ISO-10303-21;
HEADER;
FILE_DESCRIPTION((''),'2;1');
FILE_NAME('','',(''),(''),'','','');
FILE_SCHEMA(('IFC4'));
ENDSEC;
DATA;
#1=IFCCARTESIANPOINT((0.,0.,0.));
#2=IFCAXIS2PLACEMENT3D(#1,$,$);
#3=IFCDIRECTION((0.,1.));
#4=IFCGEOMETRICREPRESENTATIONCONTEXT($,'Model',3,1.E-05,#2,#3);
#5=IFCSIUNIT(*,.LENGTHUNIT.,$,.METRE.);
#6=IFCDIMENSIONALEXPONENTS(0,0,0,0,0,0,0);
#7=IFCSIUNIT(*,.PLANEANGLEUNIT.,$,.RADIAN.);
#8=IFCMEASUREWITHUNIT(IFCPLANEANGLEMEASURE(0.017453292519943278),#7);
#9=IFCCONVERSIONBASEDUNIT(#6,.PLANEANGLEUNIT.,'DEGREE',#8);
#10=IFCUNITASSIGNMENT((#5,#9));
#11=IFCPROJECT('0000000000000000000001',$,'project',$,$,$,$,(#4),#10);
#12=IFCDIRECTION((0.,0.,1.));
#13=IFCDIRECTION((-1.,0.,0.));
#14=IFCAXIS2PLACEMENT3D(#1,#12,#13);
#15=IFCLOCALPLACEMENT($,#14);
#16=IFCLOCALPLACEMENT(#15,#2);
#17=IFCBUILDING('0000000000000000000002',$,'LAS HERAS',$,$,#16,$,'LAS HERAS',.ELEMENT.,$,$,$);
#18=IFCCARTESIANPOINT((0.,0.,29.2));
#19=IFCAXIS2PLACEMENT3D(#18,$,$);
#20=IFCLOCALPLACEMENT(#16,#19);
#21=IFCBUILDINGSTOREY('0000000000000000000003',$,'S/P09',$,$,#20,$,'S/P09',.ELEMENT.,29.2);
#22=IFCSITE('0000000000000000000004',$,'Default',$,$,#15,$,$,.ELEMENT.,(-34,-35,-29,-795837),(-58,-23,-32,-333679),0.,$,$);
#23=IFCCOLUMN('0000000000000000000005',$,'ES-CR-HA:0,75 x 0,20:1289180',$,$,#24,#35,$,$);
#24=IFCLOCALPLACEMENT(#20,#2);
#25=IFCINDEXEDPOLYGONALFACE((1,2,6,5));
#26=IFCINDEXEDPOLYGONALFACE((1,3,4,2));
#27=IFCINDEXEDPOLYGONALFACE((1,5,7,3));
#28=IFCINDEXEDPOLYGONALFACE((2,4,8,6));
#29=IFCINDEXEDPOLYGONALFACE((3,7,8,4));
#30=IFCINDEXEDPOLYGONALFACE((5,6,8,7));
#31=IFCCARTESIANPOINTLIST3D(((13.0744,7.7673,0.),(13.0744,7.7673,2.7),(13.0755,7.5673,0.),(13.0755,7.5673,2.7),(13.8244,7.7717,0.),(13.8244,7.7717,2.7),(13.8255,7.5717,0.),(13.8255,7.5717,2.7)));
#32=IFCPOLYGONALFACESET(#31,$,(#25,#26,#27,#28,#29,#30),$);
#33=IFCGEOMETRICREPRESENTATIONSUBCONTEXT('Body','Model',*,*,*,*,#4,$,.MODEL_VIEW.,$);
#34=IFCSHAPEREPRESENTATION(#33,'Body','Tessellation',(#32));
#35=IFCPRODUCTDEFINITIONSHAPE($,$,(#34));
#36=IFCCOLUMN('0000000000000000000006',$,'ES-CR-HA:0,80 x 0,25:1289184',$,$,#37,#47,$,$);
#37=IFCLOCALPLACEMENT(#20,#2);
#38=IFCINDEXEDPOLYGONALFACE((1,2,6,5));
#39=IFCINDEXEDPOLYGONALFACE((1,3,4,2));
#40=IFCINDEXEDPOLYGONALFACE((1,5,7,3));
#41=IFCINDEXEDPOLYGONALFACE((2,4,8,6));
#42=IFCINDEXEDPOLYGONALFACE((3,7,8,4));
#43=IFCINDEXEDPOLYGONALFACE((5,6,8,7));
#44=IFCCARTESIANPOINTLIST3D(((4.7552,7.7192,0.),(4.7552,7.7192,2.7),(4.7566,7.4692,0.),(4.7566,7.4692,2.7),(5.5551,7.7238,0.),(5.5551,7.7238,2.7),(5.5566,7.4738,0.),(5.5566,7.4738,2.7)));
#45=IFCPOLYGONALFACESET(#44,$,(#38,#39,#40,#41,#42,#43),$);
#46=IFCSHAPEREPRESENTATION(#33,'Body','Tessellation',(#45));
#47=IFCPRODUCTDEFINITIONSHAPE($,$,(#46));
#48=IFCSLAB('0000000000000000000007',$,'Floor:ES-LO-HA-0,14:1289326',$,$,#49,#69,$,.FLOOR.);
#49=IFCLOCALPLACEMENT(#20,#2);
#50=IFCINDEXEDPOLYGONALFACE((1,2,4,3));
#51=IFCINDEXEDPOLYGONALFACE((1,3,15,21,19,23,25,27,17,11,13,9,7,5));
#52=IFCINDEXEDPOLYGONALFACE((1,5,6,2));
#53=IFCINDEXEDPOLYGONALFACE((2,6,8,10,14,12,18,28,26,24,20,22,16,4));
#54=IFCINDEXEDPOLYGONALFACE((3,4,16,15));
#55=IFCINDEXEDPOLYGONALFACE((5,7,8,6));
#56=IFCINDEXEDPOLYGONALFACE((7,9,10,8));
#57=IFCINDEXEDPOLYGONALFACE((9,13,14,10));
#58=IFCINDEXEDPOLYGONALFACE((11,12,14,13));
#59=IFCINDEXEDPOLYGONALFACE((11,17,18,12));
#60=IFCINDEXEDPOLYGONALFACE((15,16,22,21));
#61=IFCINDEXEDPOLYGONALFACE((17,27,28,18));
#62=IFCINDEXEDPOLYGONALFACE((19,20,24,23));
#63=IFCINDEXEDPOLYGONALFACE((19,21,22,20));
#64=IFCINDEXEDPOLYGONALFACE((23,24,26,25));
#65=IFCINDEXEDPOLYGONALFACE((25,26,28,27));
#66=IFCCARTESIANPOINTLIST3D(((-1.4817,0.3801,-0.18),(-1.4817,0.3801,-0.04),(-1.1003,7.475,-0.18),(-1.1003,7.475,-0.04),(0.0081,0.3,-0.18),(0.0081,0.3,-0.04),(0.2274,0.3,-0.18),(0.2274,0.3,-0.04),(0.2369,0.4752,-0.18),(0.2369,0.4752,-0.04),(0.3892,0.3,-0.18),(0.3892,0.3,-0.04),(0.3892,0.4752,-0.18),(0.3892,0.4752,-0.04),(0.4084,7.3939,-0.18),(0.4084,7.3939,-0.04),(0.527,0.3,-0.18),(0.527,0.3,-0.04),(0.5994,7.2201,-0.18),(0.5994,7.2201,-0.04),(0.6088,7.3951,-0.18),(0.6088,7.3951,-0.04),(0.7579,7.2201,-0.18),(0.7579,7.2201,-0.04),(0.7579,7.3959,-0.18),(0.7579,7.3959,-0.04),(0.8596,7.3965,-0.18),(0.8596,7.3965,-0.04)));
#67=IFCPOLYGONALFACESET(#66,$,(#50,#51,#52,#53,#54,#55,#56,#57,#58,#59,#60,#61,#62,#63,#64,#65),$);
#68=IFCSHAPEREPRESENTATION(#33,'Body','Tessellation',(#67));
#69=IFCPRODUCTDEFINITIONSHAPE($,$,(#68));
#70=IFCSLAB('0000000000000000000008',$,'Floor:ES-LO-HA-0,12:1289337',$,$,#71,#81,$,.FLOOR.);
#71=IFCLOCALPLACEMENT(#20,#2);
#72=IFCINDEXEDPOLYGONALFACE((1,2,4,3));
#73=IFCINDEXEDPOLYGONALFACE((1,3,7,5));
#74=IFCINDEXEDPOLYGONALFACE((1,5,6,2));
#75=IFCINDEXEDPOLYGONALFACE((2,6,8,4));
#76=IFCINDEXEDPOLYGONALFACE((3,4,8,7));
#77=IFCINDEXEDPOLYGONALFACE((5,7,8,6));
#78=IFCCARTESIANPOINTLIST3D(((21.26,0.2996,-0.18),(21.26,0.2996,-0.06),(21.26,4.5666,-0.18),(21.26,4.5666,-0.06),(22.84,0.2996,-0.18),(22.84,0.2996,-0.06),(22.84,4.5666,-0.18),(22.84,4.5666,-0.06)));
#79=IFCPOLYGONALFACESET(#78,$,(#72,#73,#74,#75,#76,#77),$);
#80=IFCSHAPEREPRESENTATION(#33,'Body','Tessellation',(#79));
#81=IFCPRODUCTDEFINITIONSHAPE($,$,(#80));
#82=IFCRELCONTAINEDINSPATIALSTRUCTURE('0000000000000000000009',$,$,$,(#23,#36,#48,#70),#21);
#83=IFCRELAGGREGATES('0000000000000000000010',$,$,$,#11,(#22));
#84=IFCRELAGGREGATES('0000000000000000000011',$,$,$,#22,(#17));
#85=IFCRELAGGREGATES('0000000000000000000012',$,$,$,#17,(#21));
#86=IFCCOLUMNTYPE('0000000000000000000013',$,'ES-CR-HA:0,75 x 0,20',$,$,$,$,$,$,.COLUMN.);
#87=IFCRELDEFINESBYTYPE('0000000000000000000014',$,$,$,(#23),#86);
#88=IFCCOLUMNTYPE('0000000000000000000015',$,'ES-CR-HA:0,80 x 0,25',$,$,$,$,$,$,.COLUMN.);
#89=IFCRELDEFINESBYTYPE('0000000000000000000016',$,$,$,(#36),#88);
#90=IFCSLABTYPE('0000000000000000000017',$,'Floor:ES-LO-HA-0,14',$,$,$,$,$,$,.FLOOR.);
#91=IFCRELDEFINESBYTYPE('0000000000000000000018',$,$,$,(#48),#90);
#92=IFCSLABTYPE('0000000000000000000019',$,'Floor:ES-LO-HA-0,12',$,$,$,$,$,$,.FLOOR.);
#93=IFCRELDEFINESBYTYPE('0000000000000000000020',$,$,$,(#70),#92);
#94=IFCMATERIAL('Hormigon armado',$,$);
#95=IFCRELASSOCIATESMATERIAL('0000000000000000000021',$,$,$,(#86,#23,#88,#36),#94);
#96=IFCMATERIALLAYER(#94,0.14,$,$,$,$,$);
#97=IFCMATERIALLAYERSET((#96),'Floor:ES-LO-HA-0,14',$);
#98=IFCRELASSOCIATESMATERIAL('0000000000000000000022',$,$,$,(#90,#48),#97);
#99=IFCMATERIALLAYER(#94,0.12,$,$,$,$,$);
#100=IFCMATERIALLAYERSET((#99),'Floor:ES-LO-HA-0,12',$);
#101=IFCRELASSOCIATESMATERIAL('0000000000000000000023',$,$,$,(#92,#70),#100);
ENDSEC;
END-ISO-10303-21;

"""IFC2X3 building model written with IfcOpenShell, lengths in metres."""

from ifc_helpers import new_model, entity, si_unit, converted_unit, direction, frame, frame_2d, origin, place, context, subcontext, project, spatial, polyline, rectangle, outline, extrude, source, transform, mapped, material, layer, layer_set, layer_usage, type_object, type_shapes, element, save


model = new_model("IFC2X3")

# Units and contexts
model_context = context("Model", 3, precision=1e-05, world=origin(), true_north=direction((0.0, 1.0)))
body_context = subcontext(model_context, "Body", "Model", "MODEL_VIEW")
ifc_project = project(units=[si_unit("LENGTHUNIT", "METRE"), converted_unit("PLANEANGLEUNIT", "DEGREE", entity("IfcPlaneAngleMeasure", 0.017453292519943278), si_unit("PLANEANGLEUNIT", "RADIAN"), dimensions=[0, 0, 0, 0, 0, 0, 0])], contexts=[model_context])

# Site, building, storey
site_placement = place(None, frame((0.0, 0.0, 0.0), z_axis=(0.0, 0.0, 1.0), x_axis=(-1.0, 0.0, 0.0)))
site = spatial("IfcSite", under=ifc_project, at=site_placement, Name="Default", CompositionType="ELEMENT", RefLatitude=(-34, -35, -29, -795837), RefLongitude=(-58, -23, -32, -333679), RefElevation=0.0)
building_placement = place(site_placement, origin())
building = spatial("IfcBuilding", under=site, at=building_placement, Name="LAS HERAS", LongName="LAS HERAS", CompositionType="ELEMENT")
storey_placement = place(building_placement, frame((0.0, 0.0, 29.2)))
storey = spatial("IfcBuildingStorey", under=building, at=storey_placement, Name="S/P09", LongName="S/P09", CompositionType="ELEMENT", Elevation=29.2)

# Columns
ifc_material = material(Name="Hormigon armado")
column_type_1 = type_object("IfcColumnType", Name="ES-CR-HA:0,75 x 0,20", PredefinedType="COLUMN", material=ifc_material)
shared_shape_1 = source(origin(), body_context, "Body", "SweptSolid", [
    extrude(rectangle(XDim=0.75, YDim=0.2, at=frame_2d((0.0, 0.0), x_axis=(1.0, 0.0))), frame((13.4499, 7.6695, 29.2), z_axis=(0.0, 0.0, 1.0), x_axis=(-0.999983, -0.005788, 0.0)), (0.0, 0.0, 1.0), 2.7),
])
type_shapes(column_type_1, [shared_shape_1])
column_1_placement = place(storey_placement, frame((0.0, 0.0, -29.2)))
element("IfcColumn", 1, at=column_1_placement, inside=storey, type_object=column_type_1, material=ifc_material, Name="ES-CR-HA:0,75 x 0,20:1289180", context=body_context, shape_type="MappedRepresentation", body=[
    mapped(shared_shape_1, transform((0.0, 0.0, 0.0), scale=1.0)),
])
column_type_2 = type_object("IfcColumnType", Name="ES-CR-HA:0,80 x 0,25", PredefinedType="COLUMN", material=ifc_material)
shared_shape_2 = source(origin(), body_context, "Body", "SweptSolid", [
    extrude(rectangle(XDim=0.8, YDim=0.25, at=frame_2d((0.0, 0.0), x_axis=(1.0, 0.0))), frame((5.1559, 7.5965, 29.2), z_axis=(0.0, 0.0, 1.0), x_axis=(-0.999983, -0.005788, 0.0)), (0.0, 0.0, 1.0), 2.7),
])
type_shapes(column_type_2, [shared_shape_2])
column_2_placement = place(storey_placement, frame((0.0, 0.0, -29.2)))
element("IfcColumn", 2, at=column_2_placement, inside=storey, type_object=column_type_2, material=ifc_material, Name="ES-CR-HA:0,80 x 0,25:1289184", context=body_context, shape_type="MappedRepresentation", body=[
    mapped(shared_shape_2, transform((0.0, 0.0, 0.0), scale=1.0)),
])

# Slab, openings
ifc_layer_1 = layer(ifc_material, 0.14)
ifc_layer_set_1 = layer_set([ifc_layer_1], Name="Floor:ES-LO-HA-0,14")
ifc_layer_usage_1 = layer_usage(ifc_layer_set_1, "AXIS3", "POSITIVE", 0.0)
slab_type_1 = type_object("IfcSlabType", Name="Floor:ES-LO-HA-0,14", PredefinedType="FLOOR", material=ifc_layer_set_1)
slab_1_placement = place(storey_placement, origin())
slab_1 = element("IfcSlab", 3, at=slab_1_placement, inside=storey, type_object=slab_type_1, material=ifc_layer_usage_1, Name="Floor:ES-LO-HA-0,14:1289326", PredefinedType="FLOOR", context=body_context, shape_type="SweptSolid", body=[
    extrude(outline(polyline([(-0.2993, -3.5591), (-0.1615, -3.5591), (-0.1615, -3.3839), (-0.0091, -3.3839), (0.0003, -3.5591), (0.2196, -3.5591), (1.7094, -3.479), (1.328, 3.6159), (-0.1807, 3.5348), (-0.3811, 3.536), (-0.3717, 3.3611), (-0.5302, 3.3611), (-0.5302, 3.5368), (-0.6319, 3.5374), (-0.2993, -3.5591)])), frame((0.2277, 3.8591, -0.04), z_axis=(0.0, 0.0, -1.0), x_axis=(-1.0, 0.0, 0.0)), (0.0, 0.0, 1.0), 0.14),
])
opening_1_placement = place(slab_1_placement, origin())
element("IfcOpeningElement", 4, at=opening_1_placement, cuts=slab_1, ObjectType="Opening", context=body_context, shape_type="SweptSolid", body=[
    extrude(outline(polyline([(0.2369, 0.4752), (0.2274, 0.3), (0.3892, 0.3), (0.3892, 0.4752), (0.2369, 0.4752)])), frame((0.0, 0.0, -0.04)), (0.0, 0.0, -1.0), 0.14),
])
opening_2_placement = place(slab_1_placement, origin())
element("IfcOpeningElement", 5, at=opening_2_placement, cuts=slab_1, ObjectType="Opening", context=body_context, shape_type="SweptSolid", body=[
    extrude(outline(polyline([(0.7579, 7.2201), (0.7579, 7.3959), (0.6088, 7.3951), (0.5994, 7.2201), (0.7579, 7.2201)])), frame((0.0, 0.0, -0.04)), (0.0, 0.0, -1.0), 0.14),
])

# Slab
ifc_layer_2 = layer(ifc_material, 0.12)
ifc_layer_set_2 = layer_set([ifc_layer_2], Name="Floor:ES-LO-HA-0,12")
ifc_layer_usage_2 = layer_usage(ifc_layer_set_2, "AXIS3", "POSITIVE", 0.0)
slab_type_2 = type_object("IfcSlabType", Name="Floor:ES-LO-HA-0,12", PredefinedType="FLOOR", material=ifc_layer_set_2)
slab_2_placement = place(storey_placement, origin())
element("IfcSlab", 6, at=slab_2_placement, inside=storey, type_object=slab_type_2, material=ifc_layer_usage_2, Name="Floor:ES-LO-HA-0,12:1289337", PredefinedType="FLOOR", context=body_context, shape_type="SweptSolid", body=[
    extrude(rectangle(XDim=4.2671, YDim=1.58, at=frame_2d((0.0, 0.0), x_axis=(1.0, 0.0))), frame((22.05, 2.4331, -0.06), z_axis=(0.0, 0.0, -1.0), x_axis=(0.0, 1.0, 0.0)), (0.0, 0.0, 1.0), 0.12),
])

save(model, "model.ifc")
